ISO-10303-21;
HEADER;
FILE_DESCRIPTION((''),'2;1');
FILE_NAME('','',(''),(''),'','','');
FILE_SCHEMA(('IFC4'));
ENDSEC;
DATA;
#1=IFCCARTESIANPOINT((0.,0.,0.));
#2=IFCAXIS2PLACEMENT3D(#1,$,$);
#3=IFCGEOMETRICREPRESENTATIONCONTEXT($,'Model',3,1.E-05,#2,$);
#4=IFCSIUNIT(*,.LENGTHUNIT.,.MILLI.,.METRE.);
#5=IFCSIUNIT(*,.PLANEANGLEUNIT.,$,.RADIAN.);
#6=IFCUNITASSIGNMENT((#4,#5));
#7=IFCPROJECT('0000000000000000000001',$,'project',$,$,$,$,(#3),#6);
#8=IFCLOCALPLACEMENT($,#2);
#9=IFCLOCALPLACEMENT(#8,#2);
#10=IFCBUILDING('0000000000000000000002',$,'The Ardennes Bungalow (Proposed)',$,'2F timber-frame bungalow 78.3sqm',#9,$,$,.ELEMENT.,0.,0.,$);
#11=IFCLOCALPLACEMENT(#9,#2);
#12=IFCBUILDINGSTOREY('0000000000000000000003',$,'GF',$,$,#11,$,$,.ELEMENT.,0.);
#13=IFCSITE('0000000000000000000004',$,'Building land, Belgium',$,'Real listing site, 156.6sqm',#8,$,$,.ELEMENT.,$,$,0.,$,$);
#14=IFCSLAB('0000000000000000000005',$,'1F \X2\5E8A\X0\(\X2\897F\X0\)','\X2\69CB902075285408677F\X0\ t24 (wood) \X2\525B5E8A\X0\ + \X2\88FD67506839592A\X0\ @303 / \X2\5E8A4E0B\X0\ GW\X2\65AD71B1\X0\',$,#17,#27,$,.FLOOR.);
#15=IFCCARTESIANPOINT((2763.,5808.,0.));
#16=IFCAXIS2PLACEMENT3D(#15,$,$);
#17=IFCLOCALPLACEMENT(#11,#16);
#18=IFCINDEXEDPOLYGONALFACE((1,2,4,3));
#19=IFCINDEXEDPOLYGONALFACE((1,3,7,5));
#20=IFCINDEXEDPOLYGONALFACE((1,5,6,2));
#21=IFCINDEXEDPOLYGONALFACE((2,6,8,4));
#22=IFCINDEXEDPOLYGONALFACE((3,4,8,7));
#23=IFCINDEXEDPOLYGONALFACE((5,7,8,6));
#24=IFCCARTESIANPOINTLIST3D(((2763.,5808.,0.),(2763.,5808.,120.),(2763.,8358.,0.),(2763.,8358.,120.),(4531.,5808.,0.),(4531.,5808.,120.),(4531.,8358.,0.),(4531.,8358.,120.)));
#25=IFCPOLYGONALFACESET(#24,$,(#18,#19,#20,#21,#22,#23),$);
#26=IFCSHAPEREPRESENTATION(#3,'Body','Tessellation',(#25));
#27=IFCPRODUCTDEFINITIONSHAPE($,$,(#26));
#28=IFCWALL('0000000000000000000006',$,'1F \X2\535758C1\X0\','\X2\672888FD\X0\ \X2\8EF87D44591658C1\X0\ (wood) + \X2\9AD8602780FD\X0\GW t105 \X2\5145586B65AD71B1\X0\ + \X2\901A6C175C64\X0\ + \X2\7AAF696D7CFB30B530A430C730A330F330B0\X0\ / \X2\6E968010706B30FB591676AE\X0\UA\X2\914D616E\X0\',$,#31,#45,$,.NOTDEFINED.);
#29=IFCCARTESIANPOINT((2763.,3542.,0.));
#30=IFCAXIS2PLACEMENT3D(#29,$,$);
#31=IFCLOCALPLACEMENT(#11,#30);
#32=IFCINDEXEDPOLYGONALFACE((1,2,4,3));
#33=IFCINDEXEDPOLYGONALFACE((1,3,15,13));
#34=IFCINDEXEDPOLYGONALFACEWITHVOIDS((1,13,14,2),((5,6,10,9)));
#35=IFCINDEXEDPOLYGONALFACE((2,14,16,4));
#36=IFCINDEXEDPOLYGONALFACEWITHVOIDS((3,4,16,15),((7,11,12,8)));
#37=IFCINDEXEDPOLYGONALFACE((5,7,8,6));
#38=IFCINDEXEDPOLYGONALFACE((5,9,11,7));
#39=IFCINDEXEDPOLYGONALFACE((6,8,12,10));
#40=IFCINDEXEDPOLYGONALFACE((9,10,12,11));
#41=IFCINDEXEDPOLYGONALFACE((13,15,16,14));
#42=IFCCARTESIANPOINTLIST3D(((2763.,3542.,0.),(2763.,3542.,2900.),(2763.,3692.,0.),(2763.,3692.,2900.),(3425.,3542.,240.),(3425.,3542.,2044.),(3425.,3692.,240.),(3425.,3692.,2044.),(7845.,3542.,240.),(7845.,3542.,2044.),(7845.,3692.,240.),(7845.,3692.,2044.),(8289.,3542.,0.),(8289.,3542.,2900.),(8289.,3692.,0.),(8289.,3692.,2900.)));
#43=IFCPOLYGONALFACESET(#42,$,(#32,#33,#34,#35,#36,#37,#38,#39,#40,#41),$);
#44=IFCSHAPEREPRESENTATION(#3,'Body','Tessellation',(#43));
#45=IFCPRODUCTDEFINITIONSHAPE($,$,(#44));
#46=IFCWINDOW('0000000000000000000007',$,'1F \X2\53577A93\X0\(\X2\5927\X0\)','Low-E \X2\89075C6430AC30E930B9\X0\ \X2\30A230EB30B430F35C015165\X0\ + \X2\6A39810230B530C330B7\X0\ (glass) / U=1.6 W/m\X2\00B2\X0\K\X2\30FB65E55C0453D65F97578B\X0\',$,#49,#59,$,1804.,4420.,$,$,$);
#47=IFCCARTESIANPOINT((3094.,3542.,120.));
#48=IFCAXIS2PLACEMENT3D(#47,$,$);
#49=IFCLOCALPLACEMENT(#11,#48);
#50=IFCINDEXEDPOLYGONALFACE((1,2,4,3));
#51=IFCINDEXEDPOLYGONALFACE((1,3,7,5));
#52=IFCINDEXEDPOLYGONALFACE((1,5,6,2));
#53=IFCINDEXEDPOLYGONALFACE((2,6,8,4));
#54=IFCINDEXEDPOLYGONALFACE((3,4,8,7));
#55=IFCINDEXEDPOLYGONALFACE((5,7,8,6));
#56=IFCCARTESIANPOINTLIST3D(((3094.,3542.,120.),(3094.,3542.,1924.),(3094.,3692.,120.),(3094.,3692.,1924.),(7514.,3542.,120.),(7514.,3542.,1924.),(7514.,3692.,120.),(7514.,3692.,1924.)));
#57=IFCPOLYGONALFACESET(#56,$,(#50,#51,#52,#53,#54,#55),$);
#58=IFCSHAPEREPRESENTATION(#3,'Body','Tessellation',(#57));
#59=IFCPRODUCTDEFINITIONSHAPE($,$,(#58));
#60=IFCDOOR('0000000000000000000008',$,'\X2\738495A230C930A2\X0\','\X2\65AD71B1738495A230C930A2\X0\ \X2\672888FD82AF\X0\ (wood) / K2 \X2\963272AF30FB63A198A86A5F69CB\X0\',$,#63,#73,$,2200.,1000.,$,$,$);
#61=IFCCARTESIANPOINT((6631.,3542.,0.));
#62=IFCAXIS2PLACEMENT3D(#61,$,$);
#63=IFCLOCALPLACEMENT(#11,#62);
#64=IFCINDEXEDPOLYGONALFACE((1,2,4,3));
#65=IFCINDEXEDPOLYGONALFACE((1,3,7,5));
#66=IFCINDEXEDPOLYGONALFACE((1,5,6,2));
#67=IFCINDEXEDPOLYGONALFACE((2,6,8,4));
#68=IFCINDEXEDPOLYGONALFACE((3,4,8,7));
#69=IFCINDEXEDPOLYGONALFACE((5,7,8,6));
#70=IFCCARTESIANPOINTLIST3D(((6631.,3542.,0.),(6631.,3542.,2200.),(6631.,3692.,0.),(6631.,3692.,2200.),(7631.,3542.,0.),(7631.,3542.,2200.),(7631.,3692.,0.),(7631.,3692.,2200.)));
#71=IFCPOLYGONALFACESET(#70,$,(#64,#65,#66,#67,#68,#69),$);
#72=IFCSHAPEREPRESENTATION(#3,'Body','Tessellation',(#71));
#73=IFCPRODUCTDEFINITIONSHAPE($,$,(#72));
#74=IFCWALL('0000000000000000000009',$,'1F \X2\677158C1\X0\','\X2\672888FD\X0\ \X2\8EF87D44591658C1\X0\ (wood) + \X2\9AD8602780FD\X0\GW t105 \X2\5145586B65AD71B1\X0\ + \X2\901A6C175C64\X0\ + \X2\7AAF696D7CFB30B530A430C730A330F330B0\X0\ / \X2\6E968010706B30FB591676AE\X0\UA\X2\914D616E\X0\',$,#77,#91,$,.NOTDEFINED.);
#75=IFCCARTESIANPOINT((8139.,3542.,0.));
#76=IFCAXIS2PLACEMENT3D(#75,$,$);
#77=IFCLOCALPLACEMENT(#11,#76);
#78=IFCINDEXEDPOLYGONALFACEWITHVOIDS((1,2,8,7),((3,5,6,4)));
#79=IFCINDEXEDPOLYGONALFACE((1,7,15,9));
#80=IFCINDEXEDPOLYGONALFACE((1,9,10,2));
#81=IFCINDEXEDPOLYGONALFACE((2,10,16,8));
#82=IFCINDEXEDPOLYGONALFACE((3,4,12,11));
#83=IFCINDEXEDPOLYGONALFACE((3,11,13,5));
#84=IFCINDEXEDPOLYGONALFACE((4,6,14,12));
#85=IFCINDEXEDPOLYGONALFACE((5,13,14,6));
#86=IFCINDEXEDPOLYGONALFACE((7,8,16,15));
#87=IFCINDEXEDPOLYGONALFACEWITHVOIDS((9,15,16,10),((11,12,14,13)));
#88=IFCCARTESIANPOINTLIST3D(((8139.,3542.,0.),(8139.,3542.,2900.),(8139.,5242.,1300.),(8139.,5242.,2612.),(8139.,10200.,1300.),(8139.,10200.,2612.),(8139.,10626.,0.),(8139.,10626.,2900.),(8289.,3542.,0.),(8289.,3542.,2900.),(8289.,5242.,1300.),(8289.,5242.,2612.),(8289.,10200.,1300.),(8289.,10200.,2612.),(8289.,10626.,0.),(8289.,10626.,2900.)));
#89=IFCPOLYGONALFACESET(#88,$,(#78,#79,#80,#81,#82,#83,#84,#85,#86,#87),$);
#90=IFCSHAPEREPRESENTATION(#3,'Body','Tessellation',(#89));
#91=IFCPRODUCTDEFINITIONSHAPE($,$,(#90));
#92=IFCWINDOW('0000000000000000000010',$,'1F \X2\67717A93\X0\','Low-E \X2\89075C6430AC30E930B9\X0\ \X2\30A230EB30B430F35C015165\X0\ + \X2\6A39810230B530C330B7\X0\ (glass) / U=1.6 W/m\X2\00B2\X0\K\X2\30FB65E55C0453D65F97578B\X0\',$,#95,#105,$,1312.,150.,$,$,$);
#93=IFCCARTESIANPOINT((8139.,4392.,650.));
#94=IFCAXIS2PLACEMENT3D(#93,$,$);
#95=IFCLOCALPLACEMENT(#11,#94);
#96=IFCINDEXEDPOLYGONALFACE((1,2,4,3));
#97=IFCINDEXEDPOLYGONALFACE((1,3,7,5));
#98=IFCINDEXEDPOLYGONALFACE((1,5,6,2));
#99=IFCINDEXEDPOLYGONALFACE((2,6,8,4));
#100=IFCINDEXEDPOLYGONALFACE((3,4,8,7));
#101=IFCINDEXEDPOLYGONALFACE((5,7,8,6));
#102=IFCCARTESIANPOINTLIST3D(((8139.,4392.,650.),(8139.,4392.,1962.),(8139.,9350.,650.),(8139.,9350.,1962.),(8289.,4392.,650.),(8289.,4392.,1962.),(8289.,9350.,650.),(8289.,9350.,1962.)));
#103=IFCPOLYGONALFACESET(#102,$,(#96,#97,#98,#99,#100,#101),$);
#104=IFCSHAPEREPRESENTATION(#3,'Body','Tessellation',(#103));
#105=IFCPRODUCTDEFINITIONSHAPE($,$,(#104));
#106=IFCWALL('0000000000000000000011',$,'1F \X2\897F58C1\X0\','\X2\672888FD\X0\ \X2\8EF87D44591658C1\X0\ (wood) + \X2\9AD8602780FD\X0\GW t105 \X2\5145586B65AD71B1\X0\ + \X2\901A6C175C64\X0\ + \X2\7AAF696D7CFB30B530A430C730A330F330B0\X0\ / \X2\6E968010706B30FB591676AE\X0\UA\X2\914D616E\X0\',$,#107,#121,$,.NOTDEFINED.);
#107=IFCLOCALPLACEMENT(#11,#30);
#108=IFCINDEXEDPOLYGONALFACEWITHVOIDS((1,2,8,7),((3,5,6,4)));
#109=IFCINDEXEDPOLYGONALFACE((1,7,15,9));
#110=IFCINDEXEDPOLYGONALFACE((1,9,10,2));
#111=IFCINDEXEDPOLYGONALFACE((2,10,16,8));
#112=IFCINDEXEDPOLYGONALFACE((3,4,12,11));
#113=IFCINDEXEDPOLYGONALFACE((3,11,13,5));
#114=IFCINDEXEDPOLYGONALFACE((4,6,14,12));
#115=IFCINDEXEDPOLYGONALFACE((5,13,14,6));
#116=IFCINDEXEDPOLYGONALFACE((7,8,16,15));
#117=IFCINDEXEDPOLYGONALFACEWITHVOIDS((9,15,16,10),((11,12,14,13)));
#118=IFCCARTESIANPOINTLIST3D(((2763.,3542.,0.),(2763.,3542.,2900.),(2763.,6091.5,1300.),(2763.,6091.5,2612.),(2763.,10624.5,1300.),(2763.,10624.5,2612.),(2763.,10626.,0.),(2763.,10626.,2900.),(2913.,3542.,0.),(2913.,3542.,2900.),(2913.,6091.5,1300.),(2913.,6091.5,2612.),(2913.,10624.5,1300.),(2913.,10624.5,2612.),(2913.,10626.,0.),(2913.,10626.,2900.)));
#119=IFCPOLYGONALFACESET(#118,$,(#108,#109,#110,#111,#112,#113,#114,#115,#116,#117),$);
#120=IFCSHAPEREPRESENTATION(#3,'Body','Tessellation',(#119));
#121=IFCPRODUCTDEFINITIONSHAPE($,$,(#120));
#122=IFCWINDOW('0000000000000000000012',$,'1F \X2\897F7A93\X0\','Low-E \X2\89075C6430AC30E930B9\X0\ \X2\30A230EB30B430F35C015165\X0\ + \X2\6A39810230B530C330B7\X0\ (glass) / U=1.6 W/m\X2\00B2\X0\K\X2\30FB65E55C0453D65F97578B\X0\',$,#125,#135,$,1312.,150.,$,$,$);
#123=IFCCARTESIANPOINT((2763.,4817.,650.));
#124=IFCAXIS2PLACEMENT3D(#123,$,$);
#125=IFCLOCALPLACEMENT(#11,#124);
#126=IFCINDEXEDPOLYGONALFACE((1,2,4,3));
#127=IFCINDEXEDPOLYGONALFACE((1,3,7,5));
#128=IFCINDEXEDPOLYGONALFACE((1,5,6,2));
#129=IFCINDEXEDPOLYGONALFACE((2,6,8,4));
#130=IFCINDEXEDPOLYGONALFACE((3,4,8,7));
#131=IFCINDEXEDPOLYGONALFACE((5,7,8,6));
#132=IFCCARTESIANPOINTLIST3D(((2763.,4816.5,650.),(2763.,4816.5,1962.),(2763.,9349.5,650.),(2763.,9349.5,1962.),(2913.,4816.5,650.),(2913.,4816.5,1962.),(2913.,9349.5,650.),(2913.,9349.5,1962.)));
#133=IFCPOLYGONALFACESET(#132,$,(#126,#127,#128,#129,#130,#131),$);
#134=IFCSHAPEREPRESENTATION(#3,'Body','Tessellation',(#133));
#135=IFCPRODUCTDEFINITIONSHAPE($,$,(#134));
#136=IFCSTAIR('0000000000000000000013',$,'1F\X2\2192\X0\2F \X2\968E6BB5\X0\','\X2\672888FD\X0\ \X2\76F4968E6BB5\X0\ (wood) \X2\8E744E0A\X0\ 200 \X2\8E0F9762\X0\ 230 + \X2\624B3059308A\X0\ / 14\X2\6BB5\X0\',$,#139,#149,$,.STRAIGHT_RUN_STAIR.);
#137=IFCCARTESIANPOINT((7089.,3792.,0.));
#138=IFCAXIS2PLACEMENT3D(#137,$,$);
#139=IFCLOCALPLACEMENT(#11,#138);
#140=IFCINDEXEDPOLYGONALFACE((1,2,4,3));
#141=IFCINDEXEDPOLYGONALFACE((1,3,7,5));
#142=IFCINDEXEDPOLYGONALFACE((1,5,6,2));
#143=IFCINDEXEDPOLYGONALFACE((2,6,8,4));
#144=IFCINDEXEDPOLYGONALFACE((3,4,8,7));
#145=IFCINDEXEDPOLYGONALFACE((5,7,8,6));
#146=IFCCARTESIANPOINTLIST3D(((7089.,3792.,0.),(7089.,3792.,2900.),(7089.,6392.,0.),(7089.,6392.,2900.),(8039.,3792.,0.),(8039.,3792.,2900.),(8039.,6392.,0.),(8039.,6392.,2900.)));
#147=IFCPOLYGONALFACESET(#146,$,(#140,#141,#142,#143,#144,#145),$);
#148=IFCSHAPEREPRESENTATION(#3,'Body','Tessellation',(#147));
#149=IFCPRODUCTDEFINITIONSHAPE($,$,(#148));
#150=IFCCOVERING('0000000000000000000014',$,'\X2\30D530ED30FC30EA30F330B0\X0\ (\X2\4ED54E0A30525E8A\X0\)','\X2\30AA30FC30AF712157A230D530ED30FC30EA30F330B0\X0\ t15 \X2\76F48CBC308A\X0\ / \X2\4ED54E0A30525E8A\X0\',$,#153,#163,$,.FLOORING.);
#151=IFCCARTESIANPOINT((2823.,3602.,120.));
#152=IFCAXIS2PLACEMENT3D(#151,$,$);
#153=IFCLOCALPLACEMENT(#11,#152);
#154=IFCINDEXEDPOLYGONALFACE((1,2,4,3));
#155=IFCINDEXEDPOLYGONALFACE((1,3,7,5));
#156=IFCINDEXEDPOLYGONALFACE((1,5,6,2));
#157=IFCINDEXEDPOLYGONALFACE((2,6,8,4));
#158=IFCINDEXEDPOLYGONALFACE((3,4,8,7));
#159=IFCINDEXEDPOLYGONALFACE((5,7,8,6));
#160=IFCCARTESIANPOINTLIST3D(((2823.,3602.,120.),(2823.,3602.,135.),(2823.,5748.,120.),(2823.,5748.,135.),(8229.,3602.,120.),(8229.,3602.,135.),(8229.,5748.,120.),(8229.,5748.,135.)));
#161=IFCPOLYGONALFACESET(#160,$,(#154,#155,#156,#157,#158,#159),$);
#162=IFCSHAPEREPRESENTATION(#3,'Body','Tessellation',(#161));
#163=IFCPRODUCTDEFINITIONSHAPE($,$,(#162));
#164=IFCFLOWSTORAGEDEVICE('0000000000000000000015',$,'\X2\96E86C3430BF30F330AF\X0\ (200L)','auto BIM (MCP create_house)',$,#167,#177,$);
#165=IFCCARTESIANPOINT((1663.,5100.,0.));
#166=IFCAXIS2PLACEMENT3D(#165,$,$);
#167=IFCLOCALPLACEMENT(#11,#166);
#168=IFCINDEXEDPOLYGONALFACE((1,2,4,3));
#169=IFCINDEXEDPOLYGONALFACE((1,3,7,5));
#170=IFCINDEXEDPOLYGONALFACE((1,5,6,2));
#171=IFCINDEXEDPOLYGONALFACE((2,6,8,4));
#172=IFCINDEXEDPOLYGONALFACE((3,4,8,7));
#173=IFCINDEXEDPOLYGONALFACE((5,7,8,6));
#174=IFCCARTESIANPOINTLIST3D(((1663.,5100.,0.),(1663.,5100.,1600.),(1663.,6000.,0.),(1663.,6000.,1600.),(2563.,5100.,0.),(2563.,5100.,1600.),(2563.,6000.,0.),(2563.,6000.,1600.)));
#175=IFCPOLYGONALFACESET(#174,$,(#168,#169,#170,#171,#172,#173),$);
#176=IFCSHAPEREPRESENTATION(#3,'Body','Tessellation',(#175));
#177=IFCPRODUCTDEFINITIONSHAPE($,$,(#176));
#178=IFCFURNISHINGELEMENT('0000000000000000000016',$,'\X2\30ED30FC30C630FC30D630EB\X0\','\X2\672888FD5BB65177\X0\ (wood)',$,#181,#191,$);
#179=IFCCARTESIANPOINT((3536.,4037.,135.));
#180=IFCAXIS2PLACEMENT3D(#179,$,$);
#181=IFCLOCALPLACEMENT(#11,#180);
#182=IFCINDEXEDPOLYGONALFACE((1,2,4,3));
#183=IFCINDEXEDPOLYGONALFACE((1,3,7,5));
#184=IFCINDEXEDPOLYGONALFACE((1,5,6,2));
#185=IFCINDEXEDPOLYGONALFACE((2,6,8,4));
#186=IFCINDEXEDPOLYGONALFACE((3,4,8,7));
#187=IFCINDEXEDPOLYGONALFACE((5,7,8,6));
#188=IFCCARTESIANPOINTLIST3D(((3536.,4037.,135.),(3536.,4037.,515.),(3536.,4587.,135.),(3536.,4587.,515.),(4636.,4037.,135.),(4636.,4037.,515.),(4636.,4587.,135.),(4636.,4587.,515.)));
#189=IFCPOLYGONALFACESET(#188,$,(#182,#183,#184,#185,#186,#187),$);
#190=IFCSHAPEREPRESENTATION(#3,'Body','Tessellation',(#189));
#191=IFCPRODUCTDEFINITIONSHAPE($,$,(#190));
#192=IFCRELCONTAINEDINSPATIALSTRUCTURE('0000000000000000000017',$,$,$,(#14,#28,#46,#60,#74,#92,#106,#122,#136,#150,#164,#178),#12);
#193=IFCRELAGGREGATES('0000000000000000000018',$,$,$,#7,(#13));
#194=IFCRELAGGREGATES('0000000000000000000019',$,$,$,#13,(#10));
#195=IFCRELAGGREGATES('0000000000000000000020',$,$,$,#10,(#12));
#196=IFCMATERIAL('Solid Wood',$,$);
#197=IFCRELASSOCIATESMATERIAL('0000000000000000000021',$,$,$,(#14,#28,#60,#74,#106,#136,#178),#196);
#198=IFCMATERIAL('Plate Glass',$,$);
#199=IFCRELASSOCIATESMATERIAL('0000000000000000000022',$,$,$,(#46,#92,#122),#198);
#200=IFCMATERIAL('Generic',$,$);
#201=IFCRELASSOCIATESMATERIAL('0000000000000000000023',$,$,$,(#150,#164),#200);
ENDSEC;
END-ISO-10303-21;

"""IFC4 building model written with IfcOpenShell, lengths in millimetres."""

from ifc_helpers import new_model, si_unit, frame, frame_2d, origin, place, context, project, spatial, rectangle, extrude, material, element, fill, save


model = new_model("IFC4")

# Units and contexts
model_context = context("Model", 3, precision=1e-05, world=origin())
ifc_project = project(units=[si_unit("LENGTHUNIT", "METRE", prefix="MILLI"), si_unit("PLANEANGLEUNIT", "RADIAN")], contexts=[model_context])

# Site, building, storey
site_placement = place(None, origin())
site = spatial("IfcSite", under=ifc_project, at=site_placement, Name="Building land, Belgium", ObjectType="Real listing site, 156.6sqm", CompositionType="ELEMENT", RefElevation=0.0)
building_placement = place(site_placement, origin())
building = spatial("IfcBuilding", under=site, at=building_placement, Name="The Ardennes Bungalow (Proposed)", ObjectType="2F timber-frame bungalow 78.3sqm", CompositionType="ELEMENT", ElevationOfRefHeight=0.0, ElevationOfTerrain=0.0)
storey_placement = place(building_placement, origin())
storey = spatial("IfcBuildingStorey", under=building, at=storey_placement, Name="GF", CompositionType="ELEMENT", Elevation=0.0)

# Slab
ifc_material_1 = material(Name="Solid Wood")
slab_1_placement = place(storey_placement, frame((2763.0, 5808.0, 0.0)))
element("IfcSlab", 1, at=slab_1_placement, inside=storey, material=ifc_material_1, Name="1F 床(西)", Description="構造用合板 t24 (wood) 剛床 + 製材根太 @303 / 床下 GW断熱", PredefinedType="FLOOR", context=model_context, shape_type="SweptSolid", body=[
    extrude(rectangle(XDim=1768.0, YDim=2550.0, at=frame_2d((884.0, 1275.0))), frame((2763.0, 5808.0, 0.0)), (0.0, 0.0, 1.0), 120.0),
])

# Wall, openings, window, door
wall_1_placement = place(storey_placement, frame((2763.0, 3542.0, 0.0)))
wall_1 = element("IfcWall", 2, at=wall_1_placement, inside=storey, material=ifc_material_1, Name="1F 南壁", Description="木製 軸組外壁 (wood) + 高性能GW t105 充填断熱 + 通気層 + 窯業系サイディング / 準耐火・外皮UA配慮", PredefinedType="NOTDEFINED", context=model_context, shape_type="SweptSolid", body=[
    extrude(rectangle(XDim=5526.0, YDim=150.0, at=frame_2d((2763.0, 75.0))), frame((2763.0, 3542.0, 0.0)), (0.0, 0.0, 1.0), 2900.0),
])
opening_1_placement = place(storey_placement, frame((3094.0, 3542.0, 120.0)))
opening_1 = element("IfcOpeningElement", 3, at=opening_1_placement, cuts=wall_1, PredefinedType="NOTDEFINED", context=model_context, shape_type="SweptSolid", body=[
    extrude(rectangle(XDim=4420.0, YDim=150.0, at=frame_2d((2210.0, 75.0))), frame((3094.0, 3542.0, 120.0)), (0.0, 0.0, 1.0), 1804.0),
])
opening_2_placement = place(storey_placement, frame((6631.0, 3542.0, 0.0)))
opening_2 = element("IfcOpeningElement", 4, at=opening_2_placement, cuts=wall_1, PredefinedType="NOTDEFINED", context=model_context, shape_type="SweptSolid", body=[
    extrude(rectangle(XDim=1000.0, YDim=150.0, at=frame_2d((500.0, 75.0))), frame((6631.0, 3542.0, 0.0)), (0.0, 0.0, 1.0), 2200.0),
])
ifc_material_2 = material(Name="Plate Glass")
window_1_placement = place(storey_placement, frame((3094.0, 3542.0, 120.0)))
window_1 = element("IfcWindow", 5, at=window_1_placement, inside=storey, material=ifc_material_2, Name="1F 南窓(大)", Description="Low-E 複層ガラス アルゴン封入 + 樹脂サッシ (glass) / U=1.6 W/m²K・日射取得型", OverallHeight=1804.0, OverallWidth=4420.0, context=model_context, shape_type="SweptSolid", body=[
    extrude(rectangle(XDim=4420.0, YDim=150.0, at=frame_2d((2210.0, 75.0))), frame((3094.0, 3542.0, 120.0)), (0.0, 0.0, 1.0), 1804.0),
])
fill(opening_1, window_1)
door_placement = place(storey_placement, frame((6631.0, 3542.0, 0.0)))
door = element("IfcDoor", 6, at=door_placement, inside=storey, material=ifc_material_1, Name="玄関ドア", Description="断熱玄関ドア 木製芯 (wood) / K2 防犯・採風機構", OverallHeight=2200.0, OverallWidth=1000.0, context=model_context, shape_type="SweptSolid", body=[
    extrude(rectangle(XDim=1000.0, YDim=150.0, at=frame_2d((500.0, 75.0))), frame((6631.0, 3542.0, 0.0)), (0.0, 0.0, 1.0), 2200.0),
])
fill(opening_2, door)

# Walls, openings, windows
wall_2_placement = place(storey_placement, frame((8139.0, 3542.0, 0.0)))
wall_2 = element("IfcWall", 7, at=wall_2_placement, inside=storey, material=ifc_material_1, Name="1F 東壁", Description="木製 軸組外壁 (wood) + 高性能GW t105 充填断熱 + 通気層 + 窯業系サイディング / 準耐火・外皮UA配慮", PredefinedType="NOTDEFINED", context=model_context, shape_type="SweptSolid", body=[
    extrude(rectangle(XDim=150.0, YDim=7084.0, at=frame_2d((75.0, 3542.0))), frame((8139.0, 3542.0, 0.0)), (0.0, 0.0, 1.0), 2900.0),
])
opening_3_placement = place(storey_placement, frame((8139.0, 4392.0, 650.0)))
opening_3 = element("IfcOpeningElement", 8, at=opening_3_placement, cuts=wall_2, PredefinedType="NOTDEFINED", context=model_context, shape_type="SweptSolid", body=[
    extrude(rectangle(XDim=150.0, YDim=4958.0, at=frame_2d((75.0, 2479.0))), frame((8139.0, 4392.0, 650.0)), (0.0, 0.0, 1.0), 1312.0),
])
window_2_placement = place(storey_placement, frame((8139.0, 4392.0, 650.0)))
window_2 = element("IfcWindow", 9, at=window_2_placement, inside=storey, material=ifc_material_2, Name="1F 東窓", Description="Low-E 複層ガラス アルゴン封入 + 樹脂サッシ (glass) / U=1.6 W/m²K・日射取得型", OverallHeight=1312.0, OverallWidth=150.0, context=model_context, shape_type="SweptSolid", body=[
    extrude(rectangle(XDim=150.0, YDim=4958.0, at=frame_2d((75.0, 2479.0))), frame((8139.0, 4392.0, 650.0)), (0.0, 0.0, 1.0), 1312.0),
])
fill(opening_3, window_2)
wall_3_placement = place(storey_placement, frame((2763.0, 3542.0, 0.0)))
wall_3 = element("IfcWall", 10, at=wall_3_placement, inside=storey, material=ifc_material_1, Name="1F 西壁", Description="木製 軸組外壁 (wood) + 高性能GW t105 充填断熱 + 通気層 + 窯業系サイディング / 準耐火・外皮UA配慮", PredefinedType="NOTDEFINED", context=model_context, shape_type="SweptSolid", body=[
    extrude(rectangle(XDim=150.0, YDim=7084.0, at=frame_2d((75.0, 3542.0))), frame((2763.0, 3542.0, 0.0)), (0.0, 0.0, 1.0), 2900.0),
])
opening_4_placement = place(storey_placement, frame((2763.0, 4817.0, 650.0)))
opening_4 = element("IfcOpeningElement", 11, at=opening_4_placement, cuts=wall_3, PredefinedType="NOTDEFINED", context=model_context, shape_type="SweptSolid", body=[
    extrude(rectangle(XDim=150.0, YDim=4533.0, at=frame_2d((75.0, 2266.0))), frame((2763.0, 4817.0, 650.0)), (0.0, 0.0, 1.0), 1312.0),
])
window_3_placement = place(storey_placement, frame((2763.0, 4817.0, 650.0)))
window_3 = element("IfcWindow", 12, at=window_3_placement, inside=storey, material=ifc_material_2, Name="1F 西窓", Description="Low-E 複層ガラス アルゴン封入 + 樹脂サッシ (glass) / U=1.6 W/m²K・日射取得型", OverallHeight=1312.0, OverallWidth=150.0, context=model_context, shape_type="SweptSolid", body=[
    extrude(rectangle(XDim=150.0, YDim=4533.0, at=frame_2d((75.0, 2266.0))), frame((2763.0, 4817.0, 650.0)), (0.0, 0.0, 1.0), 1312.0),
])
fill(opening_4, window_3)

# Stair
stair_placement = place(storey_placement, frame((7089.0, 3792.0, 0.0)))
element("IfcStair", 13, at=stair_placement, inside=storey, material=ifc_material_1, Name="1F→2F 階段", Description="木製 直階段 (wood) 蹴上 200 踏面 230 + 手すり / 14段", PredefinedType="STRAIGHT_RUN_STAIR", context=model_context, shape_type="SweptSolid", body=[
    extrude(rectangle(XDim=950.0, YDim=2600.0, at=frame_2d((475.0, 1300.0))), frame((7089.0, 3792.0, 0.0)), (0.0, 0.0, 1.0), 2900.0),
])

# Covering
ifc_material_3 = material(Name="Generic")
covering_placement = place(storey_placement, frame((2823.0, 3602.0, 120.0)))
element("IfcCovering", 14, at=covering_placement, inside=storey, material=ifc_material_3, Name="フローリング (仕上げ床)", Description="オーク無垢フローリング t15 直貼り / 仕上げ床", PredefinedType="FLOORING", context=model_context, shape_type="SweptSolid", body=[
    extrude(rectangle(XDim=5406.0, YDim=2146.0, at=frame_2d((2703.0, 1073.0))), frame((2823.0, 3602.0, 120.0)), (0.0, 0.0, 1.0), 15.0),
])

# Flow storage device
flow_storage_device_placement = place(storey_placement, frame((1663.0, 5100.0, 0.0)))
element("IfcFlowStorageDevice", 15, at=flow_storage_device_placement, inside=storey, material=ifc_material_3, Name="雨水タンク (200L)", Description="auto BIM (MCP create_house)", context=model_context, shape_type="SweptSolid", body=[
    extrude(rectangle(XDim=900.0, YDim=900.0, at=frame_2d((450.0, 450.0))), frame((1663.0, 5100.0, 0.0)), (0.0, 0.0, 1.0), 1600.0),
])

# Furnishing element
furnishing_1_placement = place(storey_placement, frame((3536.0, 4037.0, 135.0)))
element("IfcFurnishingElement", 16, at=furnishing_1_placement, inside=storey, material=ifc_material_1, Name="ローテーブル", Description="木製家具 (wood)", context=model_context, shape_type="SweptSolid", body=[
    extrude(rectangle(XDim=1100.0, YDim=550.0, at=frame_2d((550.0, 275.0))), frame((3536.0, 4037.0, 135.0)), (0.0, 0.0, 1.0), 380.0),
])

save(model, "model.ifc")
